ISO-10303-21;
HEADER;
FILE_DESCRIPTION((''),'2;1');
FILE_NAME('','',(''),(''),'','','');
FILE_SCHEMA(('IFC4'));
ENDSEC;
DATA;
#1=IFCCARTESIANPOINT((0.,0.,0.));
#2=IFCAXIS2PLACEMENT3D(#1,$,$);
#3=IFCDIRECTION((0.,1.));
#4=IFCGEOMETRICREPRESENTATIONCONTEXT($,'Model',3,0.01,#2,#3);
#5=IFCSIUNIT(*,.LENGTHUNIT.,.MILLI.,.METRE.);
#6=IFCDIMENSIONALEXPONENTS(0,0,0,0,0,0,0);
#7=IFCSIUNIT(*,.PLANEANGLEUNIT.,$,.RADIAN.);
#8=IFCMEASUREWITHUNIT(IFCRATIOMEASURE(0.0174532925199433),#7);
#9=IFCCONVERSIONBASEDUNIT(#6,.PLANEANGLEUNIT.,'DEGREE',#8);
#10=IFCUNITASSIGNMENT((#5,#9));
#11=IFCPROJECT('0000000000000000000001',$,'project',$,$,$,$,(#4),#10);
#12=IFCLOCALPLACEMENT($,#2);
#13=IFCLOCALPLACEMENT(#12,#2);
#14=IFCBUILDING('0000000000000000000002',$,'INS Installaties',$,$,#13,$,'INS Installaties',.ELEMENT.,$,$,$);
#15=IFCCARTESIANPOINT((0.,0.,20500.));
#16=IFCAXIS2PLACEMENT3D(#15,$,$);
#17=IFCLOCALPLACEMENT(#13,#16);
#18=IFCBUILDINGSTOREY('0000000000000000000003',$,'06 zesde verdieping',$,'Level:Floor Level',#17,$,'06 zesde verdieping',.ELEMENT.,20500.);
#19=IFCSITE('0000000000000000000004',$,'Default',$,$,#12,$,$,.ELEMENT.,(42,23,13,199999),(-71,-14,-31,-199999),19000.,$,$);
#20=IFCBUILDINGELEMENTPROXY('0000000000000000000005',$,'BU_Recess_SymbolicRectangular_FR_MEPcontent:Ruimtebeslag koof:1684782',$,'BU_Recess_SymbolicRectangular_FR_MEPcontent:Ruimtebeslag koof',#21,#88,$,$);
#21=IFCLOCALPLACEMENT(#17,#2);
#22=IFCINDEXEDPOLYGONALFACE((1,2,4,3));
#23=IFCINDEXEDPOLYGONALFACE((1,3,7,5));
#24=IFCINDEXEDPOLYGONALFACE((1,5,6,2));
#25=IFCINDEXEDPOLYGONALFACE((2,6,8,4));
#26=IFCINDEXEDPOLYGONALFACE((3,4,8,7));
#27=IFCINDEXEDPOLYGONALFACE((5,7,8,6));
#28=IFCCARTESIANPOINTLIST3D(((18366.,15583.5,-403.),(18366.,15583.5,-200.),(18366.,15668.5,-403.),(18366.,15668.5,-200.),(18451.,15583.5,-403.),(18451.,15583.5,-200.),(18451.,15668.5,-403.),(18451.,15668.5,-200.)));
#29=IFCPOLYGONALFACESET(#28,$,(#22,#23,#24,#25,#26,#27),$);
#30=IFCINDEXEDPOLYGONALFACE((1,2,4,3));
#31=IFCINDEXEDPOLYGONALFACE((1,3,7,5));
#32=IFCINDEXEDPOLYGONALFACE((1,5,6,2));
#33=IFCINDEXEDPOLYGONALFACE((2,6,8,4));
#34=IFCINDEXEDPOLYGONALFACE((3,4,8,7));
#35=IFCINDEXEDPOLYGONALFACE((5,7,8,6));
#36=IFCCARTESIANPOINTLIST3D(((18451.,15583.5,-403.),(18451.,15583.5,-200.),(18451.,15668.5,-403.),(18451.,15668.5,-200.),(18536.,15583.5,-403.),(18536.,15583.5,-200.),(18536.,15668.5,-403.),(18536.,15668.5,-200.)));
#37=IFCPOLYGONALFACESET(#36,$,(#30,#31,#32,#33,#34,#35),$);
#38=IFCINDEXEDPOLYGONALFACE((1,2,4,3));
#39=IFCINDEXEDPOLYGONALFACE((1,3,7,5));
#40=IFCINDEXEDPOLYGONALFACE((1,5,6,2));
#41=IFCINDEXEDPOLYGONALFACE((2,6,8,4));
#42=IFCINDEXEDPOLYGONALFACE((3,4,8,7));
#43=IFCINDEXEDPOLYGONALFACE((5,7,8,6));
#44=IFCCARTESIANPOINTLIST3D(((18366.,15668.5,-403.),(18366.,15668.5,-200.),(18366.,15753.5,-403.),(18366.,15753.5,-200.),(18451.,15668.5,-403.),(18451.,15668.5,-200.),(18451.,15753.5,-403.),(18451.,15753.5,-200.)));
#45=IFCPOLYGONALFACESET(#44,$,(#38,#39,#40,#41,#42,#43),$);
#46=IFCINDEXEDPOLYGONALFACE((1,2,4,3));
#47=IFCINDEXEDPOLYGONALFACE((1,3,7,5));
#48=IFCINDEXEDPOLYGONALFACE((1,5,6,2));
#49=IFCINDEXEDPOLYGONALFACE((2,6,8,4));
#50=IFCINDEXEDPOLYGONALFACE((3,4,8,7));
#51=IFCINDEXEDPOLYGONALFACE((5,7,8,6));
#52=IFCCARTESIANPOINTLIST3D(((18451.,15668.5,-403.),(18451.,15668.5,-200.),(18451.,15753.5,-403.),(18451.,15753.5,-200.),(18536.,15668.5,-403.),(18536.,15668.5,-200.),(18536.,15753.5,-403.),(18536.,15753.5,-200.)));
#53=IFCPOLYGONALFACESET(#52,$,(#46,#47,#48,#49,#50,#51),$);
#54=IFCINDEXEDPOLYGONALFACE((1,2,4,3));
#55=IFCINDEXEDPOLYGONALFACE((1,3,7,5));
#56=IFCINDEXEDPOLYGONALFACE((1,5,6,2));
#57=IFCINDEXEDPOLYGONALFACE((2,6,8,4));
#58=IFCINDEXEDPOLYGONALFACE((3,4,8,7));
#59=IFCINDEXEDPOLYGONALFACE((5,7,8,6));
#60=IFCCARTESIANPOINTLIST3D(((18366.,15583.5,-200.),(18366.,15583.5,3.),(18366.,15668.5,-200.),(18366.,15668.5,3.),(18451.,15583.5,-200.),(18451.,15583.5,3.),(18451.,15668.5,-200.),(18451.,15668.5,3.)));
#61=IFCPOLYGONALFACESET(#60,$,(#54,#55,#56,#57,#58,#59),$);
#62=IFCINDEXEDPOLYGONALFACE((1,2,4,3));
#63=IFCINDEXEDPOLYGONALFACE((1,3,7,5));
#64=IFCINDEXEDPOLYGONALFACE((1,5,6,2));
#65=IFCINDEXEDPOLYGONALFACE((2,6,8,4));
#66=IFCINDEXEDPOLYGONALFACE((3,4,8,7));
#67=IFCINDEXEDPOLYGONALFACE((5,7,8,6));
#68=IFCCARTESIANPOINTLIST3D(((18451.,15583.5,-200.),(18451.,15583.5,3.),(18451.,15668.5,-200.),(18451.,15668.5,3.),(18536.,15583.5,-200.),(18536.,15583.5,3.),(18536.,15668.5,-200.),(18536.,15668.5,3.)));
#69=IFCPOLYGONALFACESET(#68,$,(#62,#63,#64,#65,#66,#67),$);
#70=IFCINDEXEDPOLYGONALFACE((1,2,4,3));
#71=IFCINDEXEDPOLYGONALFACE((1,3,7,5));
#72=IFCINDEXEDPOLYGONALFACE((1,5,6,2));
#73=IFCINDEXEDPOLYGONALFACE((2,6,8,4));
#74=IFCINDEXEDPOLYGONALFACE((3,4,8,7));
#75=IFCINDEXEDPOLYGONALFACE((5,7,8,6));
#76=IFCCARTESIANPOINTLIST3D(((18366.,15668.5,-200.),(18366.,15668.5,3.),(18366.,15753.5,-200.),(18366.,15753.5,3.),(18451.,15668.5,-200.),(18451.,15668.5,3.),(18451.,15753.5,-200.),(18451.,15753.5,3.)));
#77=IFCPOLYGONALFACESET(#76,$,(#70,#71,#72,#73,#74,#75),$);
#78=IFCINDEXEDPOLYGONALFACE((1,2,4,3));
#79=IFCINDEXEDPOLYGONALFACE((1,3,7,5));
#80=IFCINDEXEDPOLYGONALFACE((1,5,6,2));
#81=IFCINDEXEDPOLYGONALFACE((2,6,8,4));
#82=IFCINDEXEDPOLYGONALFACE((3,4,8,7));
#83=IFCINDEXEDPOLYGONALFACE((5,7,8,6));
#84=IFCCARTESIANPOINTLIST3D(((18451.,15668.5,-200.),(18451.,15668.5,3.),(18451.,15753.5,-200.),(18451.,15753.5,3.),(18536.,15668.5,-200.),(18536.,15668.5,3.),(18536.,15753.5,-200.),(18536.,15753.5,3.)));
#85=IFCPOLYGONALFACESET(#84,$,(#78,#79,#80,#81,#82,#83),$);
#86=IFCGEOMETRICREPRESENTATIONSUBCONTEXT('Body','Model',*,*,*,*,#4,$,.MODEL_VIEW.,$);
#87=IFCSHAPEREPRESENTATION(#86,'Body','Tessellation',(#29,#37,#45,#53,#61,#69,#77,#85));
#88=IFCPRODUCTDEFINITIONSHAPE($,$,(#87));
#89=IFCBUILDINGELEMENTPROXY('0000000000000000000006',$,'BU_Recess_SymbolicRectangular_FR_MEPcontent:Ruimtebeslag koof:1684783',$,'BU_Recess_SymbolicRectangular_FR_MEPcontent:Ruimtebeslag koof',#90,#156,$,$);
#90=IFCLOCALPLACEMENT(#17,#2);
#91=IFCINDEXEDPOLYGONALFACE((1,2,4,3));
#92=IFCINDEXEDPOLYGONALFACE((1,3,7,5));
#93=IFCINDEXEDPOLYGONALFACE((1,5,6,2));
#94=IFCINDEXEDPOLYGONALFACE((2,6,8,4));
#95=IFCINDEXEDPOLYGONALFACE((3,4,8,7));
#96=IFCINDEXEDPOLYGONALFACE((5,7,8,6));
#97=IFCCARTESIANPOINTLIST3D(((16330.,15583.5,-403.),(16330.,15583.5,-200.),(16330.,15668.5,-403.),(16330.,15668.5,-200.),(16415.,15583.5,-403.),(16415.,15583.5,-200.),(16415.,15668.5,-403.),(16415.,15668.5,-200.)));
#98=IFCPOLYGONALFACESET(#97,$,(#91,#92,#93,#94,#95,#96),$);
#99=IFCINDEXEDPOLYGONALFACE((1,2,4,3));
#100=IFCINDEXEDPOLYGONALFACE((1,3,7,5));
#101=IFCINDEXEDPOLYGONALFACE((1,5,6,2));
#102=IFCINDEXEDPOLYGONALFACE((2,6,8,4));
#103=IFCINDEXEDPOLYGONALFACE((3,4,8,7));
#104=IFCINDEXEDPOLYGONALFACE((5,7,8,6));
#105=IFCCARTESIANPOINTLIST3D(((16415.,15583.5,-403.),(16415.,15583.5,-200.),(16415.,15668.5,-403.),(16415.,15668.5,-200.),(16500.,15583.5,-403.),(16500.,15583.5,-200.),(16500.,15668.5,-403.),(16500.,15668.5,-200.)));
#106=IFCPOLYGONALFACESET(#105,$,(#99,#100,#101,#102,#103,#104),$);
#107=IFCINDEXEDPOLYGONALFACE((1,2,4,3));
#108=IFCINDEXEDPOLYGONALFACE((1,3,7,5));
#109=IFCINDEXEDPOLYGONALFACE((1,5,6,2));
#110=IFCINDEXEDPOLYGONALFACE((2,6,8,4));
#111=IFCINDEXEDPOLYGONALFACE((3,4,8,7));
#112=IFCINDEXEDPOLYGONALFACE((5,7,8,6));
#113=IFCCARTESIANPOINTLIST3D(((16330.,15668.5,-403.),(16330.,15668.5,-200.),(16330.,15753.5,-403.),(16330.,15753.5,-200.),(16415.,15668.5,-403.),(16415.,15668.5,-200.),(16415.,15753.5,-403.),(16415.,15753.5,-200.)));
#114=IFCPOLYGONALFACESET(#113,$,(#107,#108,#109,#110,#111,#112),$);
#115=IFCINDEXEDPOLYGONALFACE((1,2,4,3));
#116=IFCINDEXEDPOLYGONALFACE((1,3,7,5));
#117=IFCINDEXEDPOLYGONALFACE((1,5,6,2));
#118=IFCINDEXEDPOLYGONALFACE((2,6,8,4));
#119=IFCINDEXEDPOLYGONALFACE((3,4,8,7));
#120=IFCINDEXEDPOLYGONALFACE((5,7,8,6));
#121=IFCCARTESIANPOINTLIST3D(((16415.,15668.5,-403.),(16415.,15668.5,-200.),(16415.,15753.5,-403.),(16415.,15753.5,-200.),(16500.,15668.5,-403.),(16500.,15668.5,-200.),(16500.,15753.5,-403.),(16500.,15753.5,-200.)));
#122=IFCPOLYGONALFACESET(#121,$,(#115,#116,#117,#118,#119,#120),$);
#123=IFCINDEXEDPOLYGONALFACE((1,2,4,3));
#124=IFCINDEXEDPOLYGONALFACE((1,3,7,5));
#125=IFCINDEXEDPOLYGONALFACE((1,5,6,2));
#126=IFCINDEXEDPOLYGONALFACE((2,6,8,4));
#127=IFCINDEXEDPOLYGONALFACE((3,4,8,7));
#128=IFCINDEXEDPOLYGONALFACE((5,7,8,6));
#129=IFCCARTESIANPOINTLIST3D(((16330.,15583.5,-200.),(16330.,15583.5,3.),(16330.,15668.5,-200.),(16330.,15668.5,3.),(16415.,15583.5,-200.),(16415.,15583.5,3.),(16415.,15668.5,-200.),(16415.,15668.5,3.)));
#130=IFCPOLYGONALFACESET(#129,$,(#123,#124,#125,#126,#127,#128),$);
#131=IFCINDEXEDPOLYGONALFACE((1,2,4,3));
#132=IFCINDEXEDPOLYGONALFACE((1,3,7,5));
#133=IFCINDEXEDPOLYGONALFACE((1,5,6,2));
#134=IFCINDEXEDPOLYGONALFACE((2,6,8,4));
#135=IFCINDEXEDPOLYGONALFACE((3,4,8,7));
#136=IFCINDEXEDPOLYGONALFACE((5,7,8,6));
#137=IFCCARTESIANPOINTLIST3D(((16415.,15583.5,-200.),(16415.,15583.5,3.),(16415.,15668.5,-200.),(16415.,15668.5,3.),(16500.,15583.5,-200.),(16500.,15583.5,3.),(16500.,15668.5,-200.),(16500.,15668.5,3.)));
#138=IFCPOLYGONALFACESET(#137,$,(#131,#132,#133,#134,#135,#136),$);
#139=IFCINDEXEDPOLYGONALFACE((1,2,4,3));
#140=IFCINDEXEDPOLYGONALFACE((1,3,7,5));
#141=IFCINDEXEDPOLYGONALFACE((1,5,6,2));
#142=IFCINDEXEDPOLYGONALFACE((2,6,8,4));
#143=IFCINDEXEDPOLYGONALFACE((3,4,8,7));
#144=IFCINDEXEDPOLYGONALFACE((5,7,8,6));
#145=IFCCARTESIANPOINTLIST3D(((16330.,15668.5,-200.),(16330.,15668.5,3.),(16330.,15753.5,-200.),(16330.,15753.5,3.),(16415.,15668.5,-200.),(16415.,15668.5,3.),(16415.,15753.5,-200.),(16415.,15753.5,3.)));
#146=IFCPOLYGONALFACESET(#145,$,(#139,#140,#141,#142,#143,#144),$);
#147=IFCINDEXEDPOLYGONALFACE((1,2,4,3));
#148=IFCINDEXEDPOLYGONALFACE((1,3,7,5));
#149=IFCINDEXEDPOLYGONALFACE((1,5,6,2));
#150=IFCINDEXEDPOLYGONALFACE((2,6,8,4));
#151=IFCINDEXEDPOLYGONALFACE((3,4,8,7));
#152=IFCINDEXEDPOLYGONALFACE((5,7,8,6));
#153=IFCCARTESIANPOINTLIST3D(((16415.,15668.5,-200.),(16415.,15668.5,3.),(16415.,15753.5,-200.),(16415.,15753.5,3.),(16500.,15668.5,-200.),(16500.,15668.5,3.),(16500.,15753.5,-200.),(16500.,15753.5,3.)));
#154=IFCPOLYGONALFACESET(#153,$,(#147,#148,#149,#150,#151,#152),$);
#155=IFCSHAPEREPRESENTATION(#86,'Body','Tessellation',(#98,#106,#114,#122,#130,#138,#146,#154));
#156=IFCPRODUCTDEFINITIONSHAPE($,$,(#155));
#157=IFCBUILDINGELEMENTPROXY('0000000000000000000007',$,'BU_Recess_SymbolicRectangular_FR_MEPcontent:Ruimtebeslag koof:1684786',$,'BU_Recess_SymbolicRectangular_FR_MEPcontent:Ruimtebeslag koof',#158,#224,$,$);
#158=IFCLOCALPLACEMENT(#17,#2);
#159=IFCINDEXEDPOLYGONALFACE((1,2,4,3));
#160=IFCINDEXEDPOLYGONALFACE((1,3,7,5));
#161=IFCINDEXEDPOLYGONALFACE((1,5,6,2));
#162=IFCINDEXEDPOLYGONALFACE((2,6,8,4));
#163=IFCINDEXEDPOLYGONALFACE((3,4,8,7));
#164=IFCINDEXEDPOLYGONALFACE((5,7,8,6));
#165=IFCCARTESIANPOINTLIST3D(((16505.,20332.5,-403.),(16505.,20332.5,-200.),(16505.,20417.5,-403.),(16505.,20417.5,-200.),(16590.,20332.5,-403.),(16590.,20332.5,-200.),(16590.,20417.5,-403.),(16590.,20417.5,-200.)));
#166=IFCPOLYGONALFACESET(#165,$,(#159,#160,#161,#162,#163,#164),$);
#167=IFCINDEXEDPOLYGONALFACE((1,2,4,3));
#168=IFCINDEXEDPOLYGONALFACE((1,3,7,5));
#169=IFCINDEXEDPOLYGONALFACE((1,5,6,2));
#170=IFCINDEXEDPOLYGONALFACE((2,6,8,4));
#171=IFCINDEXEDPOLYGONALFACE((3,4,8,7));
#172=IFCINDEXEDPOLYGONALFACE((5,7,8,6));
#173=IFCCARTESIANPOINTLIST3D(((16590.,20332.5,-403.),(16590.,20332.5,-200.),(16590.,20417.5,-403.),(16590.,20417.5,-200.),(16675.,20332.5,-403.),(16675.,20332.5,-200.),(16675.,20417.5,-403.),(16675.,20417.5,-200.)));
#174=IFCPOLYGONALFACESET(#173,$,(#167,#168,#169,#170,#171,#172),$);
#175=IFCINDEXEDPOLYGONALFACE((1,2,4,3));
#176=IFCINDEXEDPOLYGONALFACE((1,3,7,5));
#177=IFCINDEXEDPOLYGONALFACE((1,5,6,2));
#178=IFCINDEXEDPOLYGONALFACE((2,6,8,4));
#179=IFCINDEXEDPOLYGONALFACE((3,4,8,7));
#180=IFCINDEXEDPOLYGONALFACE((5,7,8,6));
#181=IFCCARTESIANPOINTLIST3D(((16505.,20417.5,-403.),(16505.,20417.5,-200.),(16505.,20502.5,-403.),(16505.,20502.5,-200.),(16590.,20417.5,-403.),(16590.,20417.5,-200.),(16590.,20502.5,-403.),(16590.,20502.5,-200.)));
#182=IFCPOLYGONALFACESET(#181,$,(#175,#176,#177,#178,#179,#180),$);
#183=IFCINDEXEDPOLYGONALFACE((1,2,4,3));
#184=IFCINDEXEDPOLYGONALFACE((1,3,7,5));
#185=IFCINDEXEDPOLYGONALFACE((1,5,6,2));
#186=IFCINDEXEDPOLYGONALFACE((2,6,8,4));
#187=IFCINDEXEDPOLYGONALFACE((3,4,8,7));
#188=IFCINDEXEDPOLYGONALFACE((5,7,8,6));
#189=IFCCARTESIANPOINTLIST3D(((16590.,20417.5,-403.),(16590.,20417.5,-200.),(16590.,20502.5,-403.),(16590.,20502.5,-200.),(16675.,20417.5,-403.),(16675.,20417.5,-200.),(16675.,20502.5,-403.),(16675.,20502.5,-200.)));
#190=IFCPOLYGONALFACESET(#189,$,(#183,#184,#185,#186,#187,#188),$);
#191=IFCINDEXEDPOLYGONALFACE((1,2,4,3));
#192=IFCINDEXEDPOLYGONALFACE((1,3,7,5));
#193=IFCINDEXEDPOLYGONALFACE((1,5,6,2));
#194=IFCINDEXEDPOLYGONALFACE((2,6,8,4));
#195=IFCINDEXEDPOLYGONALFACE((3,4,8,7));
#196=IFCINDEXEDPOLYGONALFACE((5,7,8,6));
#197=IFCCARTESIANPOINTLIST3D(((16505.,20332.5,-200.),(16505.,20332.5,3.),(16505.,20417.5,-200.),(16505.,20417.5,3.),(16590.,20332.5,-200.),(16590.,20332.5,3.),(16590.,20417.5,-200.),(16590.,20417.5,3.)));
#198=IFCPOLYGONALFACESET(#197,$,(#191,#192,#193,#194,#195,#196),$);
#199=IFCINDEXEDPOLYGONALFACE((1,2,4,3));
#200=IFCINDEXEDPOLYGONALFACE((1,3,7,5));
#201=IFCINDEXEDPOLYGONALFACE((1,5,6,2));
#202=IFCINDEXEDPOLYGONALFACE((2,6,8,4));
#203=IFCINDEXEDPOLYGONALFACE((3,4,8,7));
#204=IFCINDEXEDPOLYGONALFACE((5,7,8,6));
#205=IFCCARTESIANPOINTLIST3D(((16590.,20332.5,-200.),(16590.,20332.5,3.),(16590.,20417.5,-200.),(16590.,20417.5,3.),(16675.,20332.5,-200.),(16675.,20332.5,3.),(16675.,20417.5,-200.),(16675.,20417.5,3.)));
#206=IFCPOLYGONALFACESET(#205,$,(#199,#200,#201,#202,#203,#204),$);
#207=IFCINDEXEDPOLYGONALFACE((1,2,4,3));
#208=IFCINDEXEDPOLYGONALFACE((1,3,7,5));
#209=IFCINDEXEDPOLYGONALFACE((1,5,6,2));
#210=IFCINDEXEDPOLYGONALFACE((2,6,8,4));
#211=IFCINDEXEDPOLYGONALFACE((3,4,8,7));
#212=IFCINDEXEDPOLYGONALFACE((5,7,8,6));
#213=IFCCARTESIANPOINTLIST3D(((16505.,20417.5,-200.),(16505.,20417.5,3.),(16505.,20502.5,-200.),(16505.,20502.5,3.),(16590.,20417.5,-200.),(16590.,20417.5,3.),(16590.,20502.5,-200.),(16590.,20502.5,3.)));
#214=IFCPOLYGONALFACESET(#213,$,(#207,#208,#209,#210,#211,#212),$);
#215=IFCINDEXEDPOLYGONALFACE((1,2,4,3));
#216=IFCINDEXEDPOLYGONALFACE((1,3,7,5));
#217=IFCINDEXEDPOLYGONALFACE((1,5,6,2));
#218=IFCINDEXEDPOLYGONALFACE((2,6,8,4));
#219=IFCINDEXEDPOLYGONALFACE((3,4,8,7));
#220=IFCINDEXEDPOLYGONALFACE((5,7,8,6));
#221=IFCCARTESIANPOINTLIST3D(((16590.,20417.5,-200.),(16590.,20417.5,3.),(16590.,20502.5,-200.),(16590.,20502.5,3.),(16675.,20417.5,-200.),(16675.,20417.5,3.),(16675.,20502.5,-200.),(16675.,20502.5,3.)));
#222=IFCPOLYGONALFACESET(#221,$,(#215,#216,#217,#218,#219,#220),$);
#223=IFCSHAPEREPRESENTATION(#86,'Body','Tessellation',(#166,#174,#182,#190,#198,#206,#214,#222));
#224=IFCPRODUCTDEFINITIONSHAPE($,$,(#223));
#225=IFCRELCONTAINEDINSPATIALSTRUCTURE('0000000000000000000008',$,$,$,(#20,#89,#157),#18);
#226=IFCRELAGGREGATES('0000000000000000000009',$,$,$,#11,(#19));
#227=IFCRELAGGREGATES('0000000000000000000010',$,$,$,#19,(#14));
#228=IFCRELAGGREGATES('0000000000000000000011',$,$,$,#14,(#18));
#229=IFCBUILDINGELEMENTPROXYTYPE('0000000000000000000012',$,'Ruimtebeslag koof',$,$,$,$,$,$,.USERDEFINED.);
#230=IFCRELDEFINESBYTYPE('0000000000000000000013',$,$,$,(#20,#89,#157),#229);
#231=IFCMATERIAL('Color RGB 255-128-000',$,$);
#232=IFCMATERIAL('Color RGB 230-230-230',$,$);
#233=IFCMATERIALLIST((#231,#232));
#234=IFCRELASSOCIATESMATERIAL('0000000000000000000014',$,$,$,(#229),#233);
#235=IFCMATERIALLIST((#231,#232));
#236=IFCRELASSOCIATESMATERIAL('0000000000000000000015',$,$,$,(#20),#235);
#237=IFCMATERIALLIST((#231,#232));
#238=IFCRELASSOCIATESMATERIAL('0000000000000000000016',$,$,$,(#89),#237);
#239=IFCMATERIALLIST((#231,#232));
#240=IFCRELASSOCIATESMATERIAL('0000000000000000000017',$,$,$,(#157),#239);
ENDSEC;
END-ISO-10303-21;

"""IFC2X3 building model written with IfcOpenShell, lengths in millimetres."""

from ifc_helpers import new_model, entity, si_unit, converted_unit, direction, frame, frame_2d, origin, origin_2d_with_axis, place, context, subcontext, project, spatial, rectangle, extrude, source, transform, mapped, material, material_list, type_object, type_shapes, element, save


model = new_model("IFC2X3")

# Units and contexts
model_context = context("Model", 3, precision=0.01, world=origin(), true_north=direction((0.0, 1.0)))
body_context = subcontext(model_context, "Body", "Model", "MODEL_VIEW")
ifc_project = project(units=[si_unit("LENGTHUNIT", "METRE", prefix="MILLI"), converted_unit("PLANEANGLEUNIT", "DEGREE", entity("IfcRatioMeasure", 0.0174532925199433), si_unit("PLANEANGLEUNIT", "RADIAN"), dimensions=[0, 0, 0, 0, 0, 0, 0])], contexts=[model_context])

# Site, building, storey
site_placement = place(None, origin())
site = spatial("IfcSite", under=ifc_project, at=site_placement, Name="Default", CompositionType="ELEMENT", RefLatitude=(42, 23, 13, 199999), RefLongitude=(-71, -14, -31, -199999), RefElevation=19000.0)
building_placement = place(site_placement, origin())
building = spatial("IfcBuilding", under=site, at=building_placement, Name="INS Installaties", LongName="INS Installaties", CompositionType="ELEMENT")
storey_placement = place(building_placement, frame((0.0, 0.0, 20500.0)))
storey = spatial("IfcBuildingStorey", under=building, at=storey_placement, Name="06 zesde verdieping", ObjectType="Level:Floor Level", LongName="06 zesde verdieping", CompositionType="ELEMENT", Elevation=20500.0)

# Building element proxies
ifc_material_1 = material(Name="Color RGB 255-128-000")
ifc_material_2 = material(Name="Color RGB 230-230-230")
ifc_material_list_1 = material_list([ifc_material_1, ifc_material_2])
building_element_proxy_type_1 = type_object("IfcBuildingElementProxyType", Name="Ruimtebeslag koof", PredefinedType="USERDEFINED", material=ifc_material_list_1)
shared_shape_1 = source(origin(), body_context, "Body", "SweptSolid", [
    extrude(rectangle(XDim=85.0, YDim=85.0, at=origin_2d_with_axis()), frame((42.5, 42.5, -403.0), z_axis=(0.0, 0.0, 1.0), x_axis=(0.0, -1.0, 0.0)), (0.0, 0.0, 1.0), 203.0),
    extrude(rectangle(XDim=85.0, YDim=85.0, at=origin_2d_with_axis()), frame((-42.5, 42.5, -403.0), z_axis=(0.0, 0.0, 1.0), x_axis=(-1.0, 0.0, 0.0)), (0.0, 0.0, 1.0), 203.0),
    extrude(rectangle(XDim=85.0, YDim=85.0, at=frame_2d((0.0, 0.0), x_axis=(1.0, 0.0))), frame((42.5, -42.5, -403.0)), (0.0, 0.0, 1.0), 203.0),
    extrude(rectangle(XDim=85.0, YDim=85.0, at=origin_2d_with_axis()), frame((-42.5, -42.5, -403.0), z_axis=(0.0, 0.0, 1.0), x_axis=(0.0, 1.0, 0.0)), (0.0, 0.0, 1.0), 203.0),
    extrude(rectangle(XDim=85.0, YDim=85.0, at=origin_2d_with_axis()), frame((42.5, 42.5, -200.0), z_axis=(0.0, 0.0, 1.0), x_axis=(0.0, -1.0, 0.0)), (0.0, 0.0, 1.0), 203.0),
    extrude(rectangle(XDim=85.0, YDim=85.0, at=frame_2d((0.0, 0.0), x_axis=(1.0, 0.0))), frame((-42.5, 42.5, -200.0), z_axis=(0.0, 0.0, 1.0), x_axis=(-1.0, 0.0, 0.0)), (0.0, 0.0, 1.0), 203.0),
    extrude(rectangle(XDim=85.0, YDim=85.0, at=frame_2d((0.0, 0.0), x_axis=(1.0, 0.0))), frame((42.5, -42.5, -200.0)), (0.0, 0.0, 1.0), 203.0),
    extrude(rectangle(XDim=85.0, YDim=85.0, at=origin_2d_with_axis()), frame((-42.5, -42.5, -200.0), z_axis=(0.0, 0.0, 1.0), x_axis=(0.0, 1.0, 0.0)), (0.0, 0.0, 1.0), 203.0),
])
type_shapes(building_element_proxy_type_1, [shared_shape_1])
ifc_material_list_2 = material_list([ifc_material_1, ifc_material_2])
proxy_1_placement = place(storey_placement, frame((18451.0, 15668.5, 0.0), z_axis=(0.0, 0.0, 1.0), x_axis=(-1.0, 0.0, 0.0)))
element("IfcBuildingElementProxy", 1, at=proxy_1_placement, inside=storey, type_object=building_element_proxy_type_1, material=ifc_material_list_2, Name="BU_Recess_SymbolicRectangular_FR_MEPcontent:Ruimtebeslag koof:1684782", ObjectType="BU_Recess_SymbolicRectangular_FR_MEPcontent:Ruimtebeslag koof", context=body_context, shape_type="MappedRepresentation", body=[
    mapped(shared_shape_1, transform((0.0, 0.0, 0.0), scale=1.0)),
])
ifc_material_list_3 = material_list([ifc_material_1, ifc_material_2])
proxy_2_placement = place(storey_placement, frame((16415.0, 15668.5, 0.0), z_axis=(0.0, 0.0, 1.0), x_axis=(-1.0, 0.0, 0.0)))
element("IfcBuildingElementProxy", 2, at=proxy_2_placement, inside=storey, type_object=building_element_proxy_type_1, material=ifc_material_list_3, Name="BU_Recess_SymbolicRectangular_FR_MEPcontent:Ruimtebeslag koof:1684783", ObjectType="BU_Recess_SymbolicRectangular_FR_MEPcontent:Ruimtebeslag koof", context=body_context, shape_type="MappedRepresentation", body=[
    mapped(shared_shape_1, transform((0.0, 0.0, 0.0), scale=1.0)),
])
ifc_material_list_4 = material_list([ifc_material_1, ifc_material_2])
proxy_3_placement = place(storey_placement, frame((16590.0, 20417.5, 0.0), z_axis=(0.0, 0.0, 1.0), x_axis=(-1.0, 0.0, 0.0)))
element("IfcBuildingElementProxy", 3, at=proxy_3_placement, inside=storey, type_object=building_element_proxy_type_1, material=ifc_material_list_4, Name="BU_Recess_SymbolicRectangular_FR_MEPcontent:Ruimtebeslag koof:1684786", ObjectType="BU_Recess_SymbolicRectangular_FR_MEPcontent:Ruimtebeslag koof", context=body_context, shape_type="MappedRepresentation", body=[
    mapped(shared_shape_1, transform((0.0, 0.0, 0.0), scale=1.0)),
])

save(model, "model.ifc")
